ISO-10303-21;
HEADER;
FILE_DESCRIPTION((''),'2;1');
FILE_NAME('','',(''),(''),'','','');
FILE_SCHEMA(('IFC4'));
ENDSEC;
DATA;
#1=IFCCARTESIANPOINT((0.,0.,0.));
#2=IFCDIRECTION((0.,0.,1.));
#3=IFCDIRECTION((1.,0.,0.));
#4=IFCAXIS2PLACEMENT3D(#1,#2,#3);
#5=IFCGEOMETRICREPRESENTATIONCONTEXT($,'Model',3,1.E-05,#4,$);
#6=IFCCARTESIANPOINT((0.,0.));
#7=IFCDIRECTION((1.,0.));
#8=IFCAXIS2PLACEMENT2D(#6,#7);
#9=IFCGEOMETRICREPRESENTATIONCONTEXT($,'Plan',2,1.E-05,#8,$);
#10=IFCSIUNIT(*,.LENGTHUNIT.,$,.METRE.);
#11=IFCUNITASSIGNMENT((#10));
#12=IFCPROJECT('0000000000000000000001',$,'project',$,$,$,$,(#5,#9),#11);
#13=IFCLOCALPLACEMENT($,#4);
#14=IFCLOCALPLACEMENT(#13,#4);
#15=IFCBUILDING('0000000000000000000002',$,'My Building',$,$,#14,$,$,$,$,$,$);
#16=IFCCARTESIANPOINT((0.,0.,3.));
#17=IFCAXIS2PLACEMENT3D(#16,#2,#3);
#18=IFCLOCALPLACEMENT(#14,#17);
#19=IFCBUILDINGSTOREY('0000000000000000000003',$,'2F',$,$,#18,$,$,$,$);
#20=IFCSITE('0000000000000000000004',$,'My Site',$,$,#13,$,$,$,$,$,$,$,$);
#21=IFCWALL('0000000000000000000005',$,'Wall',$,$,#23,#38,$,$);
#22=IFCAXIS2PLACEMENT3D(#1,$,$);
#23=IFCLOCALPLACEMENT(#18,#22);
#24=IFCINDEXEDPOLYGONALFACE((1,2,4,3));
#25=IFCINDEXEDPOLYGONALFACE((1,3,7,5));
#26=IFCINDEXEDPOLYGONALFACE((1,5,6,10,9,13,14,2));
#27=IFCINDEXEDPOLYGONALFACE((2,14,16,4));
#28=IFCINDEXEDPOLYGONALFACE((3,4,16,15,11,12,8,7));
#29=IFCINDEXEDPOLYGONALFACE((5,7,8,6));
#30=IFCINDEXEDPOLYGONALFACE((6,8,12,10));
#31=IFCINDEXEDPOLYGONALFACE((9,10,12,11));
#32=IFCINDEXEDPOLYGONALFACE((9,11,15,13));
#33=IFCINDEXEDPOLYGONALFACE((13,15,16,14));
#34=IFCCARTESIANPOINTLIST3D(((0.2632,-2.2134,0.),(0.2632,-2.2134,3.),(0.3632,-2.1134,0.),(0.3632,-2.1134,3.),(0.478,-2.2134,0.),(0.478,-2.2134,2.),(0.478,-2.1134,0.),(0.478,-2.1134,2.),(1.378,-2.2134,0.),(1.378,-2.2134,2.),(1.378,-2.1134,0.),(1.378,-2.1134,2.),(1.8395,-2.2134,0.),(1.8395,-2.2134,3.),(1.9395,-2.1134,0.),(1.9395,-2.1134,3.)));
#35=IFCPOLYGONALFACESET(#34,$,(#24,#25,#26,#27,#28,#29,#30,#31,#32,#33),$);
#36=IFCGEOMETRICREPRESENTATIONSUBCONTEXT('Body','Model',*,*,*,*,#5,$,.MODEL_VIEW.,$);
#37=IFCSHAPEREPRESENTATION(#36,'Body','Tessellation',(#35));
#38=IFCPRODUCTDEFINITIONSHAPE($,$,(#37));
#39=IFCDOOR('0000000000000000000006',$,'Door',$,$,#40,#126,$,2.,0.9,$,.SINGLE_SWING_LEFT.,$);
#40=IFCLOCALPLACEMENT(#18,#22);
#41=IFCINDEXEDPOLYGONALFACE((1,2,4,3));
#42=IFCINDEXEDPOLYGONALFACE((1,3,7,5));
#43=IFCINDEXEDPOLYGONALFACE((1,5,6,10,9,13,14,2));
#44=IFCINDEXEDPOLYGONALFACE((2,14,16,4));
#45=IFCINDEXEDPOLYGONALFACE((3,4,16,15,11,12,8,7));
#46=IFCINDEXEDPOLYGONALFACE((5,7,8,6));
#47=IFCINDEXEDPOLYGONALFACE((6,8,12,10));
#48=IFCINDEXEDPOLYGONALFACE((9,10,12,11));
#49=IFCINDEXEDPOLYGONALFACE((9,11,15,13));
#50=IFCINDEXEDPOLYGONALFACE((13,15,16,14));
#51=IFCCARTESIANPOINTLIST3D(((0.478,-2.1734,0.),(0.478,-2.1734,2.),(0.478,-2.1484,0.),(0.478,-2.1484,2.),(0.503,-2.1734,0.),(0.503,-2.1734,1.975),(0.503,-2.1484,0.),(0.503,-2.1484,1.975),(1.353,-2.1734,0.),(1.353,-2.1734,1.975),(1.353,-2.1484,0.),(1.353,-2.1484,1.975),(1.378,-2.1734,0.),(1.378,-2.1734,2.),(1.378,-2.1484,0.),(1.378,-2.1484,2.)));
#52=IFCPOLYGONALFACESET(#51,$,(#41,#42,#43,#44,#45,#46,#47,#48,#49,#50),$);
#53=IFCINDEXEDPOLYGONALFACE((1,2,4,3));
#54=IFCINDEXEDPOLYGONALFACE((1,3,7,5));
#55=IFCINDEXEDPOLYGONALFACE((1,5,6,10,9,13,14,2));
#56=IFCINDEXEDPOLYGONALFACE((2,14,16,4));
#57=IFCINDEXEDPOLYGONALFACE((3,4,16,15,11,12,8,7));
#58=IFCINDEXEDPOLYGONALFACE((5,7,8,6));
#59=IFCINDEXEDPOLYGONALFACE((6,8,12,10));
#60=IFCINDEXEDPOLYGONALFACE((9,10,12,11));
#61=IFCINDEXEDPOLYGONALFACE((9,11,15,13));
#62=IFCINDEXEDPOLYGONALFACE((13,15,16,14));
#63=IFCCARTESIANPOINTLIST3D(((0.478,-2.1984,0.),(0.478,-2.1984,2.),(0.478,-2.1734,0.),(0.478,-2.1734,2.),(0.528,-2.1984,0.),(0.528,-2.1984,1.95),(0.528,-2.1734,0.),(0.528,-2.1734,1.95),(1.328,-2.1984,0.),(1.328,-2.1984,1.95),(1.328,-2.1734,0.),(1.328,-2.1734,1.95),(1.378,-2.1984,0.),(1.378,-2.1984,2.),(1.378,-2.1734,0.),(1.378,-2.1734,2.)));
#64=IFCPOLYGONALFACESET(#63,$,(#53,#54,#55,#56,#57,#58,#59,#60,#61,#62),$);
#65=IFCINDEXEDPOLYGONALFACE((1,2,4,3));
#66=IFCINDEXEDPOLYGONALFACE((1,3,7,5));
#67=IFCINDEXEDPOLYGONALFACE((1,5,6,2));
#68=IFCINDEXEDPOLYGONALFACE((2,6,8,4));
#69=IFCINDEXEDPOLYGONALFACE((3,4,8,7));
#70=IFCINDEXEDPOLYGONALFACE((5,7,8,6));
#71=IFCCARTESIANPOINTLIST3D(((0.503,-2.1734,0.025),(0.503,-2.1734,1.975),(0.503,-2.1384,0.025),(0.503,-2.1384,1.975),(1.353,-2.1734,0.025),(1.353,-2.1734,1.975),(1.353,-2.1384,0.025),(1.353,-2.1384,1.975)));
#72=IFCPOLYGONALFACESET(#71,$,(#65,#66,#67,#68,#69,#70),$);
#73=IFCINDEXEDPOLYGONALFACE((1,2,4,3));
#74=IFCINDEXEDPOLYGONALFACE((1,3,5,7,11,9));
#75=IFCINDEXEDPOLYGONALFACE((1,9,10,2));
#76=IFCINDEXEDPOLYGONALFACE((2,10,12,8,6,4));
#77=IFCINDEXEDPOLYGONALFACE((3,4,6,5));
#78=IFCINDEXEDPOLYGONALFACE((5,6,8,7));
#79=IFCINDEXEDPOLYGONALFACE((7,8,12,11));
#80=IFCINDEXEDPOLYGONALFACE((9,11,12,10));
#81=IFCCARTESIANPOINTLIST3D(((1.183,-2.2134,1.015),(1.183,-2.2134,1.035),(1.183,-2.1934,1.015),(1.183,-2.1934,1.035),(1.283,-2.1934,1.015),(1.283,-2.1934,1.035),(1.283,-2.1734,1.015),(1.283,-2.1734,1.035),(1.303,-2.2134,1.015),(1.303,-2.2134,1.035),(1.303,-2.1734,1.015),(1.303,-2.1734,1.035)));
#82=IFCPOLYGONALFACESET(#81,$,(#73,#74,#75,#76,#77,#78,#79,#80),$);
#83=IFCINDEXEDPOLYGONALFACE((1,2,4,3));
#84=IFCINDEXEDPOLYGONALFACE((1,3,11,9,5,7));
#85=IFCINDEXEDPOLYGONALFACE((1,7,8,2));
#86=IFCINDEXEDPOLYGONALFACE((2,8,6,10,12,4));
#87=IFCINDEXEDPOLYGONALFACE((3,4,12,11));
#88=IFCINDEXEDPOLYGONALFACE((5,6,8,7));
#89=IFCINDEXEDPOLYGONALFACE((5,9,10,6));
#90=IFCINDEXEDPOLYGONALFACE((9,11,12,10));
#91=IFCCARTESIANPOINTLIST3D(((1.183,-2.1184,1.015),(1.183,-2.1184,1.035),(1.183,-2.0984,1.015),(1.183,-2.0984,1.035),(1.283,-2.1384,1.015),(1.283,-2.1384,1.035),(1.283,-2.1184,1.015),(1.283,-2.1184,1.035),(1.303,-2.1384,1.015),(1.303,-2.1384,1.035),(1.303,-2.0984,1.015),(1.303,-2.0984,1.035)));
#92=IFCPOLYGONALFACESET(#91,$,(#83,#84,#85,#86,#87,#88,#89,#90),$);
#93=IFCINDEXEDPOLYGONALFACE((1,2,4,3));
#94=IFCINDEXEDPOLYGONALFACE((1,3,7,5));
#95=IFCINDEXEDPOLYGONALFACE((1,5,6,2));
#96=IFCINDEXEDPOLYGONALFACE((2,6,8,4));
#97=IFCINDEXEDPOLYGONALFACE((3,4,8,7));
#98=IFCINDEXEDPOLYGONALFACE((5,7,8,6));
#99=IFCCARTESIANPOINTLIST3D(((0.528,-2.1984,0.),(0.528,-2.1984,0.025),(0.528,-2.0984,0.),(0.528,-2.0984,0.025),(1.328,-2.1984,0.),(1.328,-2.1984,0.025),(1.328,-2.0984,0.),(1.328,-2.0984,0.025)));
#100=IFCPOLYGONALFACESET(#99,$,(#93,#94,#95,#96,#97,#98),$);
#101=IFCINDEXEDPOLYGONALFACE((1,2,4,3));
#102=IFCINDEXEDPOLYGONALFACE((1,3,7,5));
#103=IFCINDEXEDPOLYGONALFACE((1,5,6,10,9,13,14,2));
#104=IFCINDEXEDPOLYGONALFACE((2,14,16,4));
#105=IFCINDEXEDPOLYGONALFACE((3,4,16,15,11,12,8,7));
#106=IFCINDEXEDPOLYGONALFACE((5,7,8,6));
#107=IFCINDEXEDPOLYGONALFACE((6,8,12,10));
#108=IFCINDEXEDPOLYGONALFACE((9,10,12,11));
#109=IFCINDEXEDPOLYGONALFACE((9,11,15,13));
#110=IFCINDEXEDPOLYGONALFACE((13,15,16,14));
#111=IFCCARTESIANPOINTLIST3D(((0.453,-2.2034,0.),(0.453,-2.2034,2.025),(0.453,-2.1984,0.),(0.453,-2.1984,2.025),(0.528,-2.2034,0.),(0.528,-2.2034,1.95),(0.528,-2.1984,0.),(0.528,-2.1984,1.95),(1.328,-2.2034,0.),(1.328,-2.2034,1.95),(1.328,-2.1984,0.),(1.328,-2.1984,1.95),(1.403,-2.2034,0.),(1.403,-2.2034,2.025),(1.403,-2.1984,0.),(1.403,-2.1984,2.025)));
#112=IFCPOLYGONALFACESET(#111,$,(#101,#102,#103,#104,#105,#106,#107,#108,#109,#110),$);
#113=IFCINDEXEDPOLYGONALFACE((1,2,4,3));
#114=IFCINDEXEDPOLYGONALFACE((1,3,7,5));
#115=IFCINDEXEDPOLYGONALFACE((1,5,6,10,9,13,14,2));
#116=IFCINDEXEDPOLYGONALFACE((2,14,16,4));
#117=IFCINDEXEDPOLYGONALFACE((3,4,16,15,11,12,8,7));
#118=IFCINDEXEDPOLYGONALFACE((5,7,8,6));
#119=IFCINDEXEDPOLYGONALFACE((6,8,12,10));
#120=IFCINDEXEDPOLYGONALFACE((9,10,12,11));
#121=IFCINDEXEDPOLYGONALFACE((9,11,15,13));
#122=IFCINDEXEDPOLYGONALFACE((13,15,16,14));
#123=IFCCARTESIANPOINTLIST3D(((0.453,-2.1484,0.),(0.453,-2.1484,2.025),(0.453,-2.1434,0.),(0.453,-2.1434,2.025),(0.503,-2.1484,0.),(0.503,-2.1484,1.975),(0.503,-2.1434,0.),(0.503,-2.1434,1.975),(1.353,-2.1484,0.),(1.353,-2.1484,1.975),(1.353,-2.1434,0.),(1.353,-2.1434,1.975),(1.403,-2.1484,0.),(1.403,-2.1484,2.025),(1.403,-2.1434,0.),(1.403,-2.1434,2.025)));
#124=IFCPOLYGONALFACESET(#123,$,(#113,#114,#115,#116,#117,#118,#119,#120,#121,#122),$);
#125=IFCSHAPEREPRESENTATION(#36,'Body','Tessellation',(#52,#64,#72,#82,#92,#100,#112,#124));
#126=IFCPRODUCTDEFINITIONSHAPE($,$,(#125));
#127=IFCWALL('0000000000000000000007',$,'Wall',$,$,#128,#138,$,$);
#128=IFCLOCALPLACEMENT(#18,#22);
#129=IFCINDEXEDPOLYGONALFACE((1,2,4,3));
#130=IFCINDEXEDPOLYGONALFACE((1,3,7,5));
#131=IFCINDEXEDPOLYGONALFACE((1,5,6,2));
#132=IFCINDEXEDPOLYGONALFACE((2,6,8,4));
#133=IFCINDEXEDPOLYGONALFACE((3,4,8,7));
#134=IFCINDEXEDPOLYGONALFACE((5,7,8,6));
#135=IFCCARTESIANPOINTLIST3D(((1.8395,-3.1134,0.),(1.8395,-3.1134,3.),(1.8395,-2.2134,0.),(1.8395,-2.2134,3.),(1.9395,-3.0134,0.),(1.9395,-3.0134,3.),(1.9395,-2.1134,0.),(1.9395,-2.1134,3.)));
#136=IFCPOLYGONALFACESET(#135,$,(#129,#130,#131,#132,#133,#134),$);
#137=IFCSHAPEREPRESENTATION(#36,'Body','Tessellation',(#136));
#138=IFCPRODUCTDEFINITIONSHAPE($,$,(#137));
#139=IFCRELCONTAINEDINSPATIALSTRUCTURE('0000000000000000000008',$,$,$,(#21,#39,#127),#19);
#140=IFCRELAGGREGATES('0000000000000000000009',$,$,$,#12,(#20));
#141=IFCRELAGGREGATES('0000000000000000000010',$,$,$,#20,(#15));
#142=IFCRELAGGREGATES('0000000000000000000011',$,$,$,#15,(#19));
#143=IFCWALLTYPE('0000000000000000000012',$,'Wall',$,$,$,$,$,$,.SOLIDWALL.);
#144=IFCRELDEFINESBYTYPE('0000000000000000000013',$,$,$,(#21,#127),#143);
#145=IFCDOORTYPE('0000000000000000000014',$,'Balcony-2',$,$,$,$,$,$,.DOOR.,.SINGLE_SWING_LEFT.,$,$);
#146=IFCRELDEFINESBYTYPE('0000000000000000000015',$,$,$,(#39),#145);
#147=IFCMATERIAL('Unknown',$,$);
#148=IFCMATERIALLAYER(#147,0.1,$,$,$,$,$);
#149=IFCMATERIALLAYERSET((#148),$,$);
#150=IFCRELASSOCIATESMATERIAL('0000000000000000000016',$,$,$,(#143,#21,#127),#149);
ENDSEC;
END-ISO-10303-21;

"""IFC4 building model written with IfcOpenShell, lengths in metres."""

from ifc_helpers import new_model, entity, si_unit, frame, origin_with_axes, origin_2d_with_axis, place, context, subcontext, project, spatial, line, indexed_curve, outline, extrude, shape, source, transform, mapped, material, layer, layer_set, layer_usage, type_object, type_shapes, element, fill, save


model = new_model("IFC4")

# Units and contexts
model_context_1 = context("Model", 3, precision=1e-05, world=origin_with_axes())
plan_context = context("Plan", 2, precision=1e-05, world=origin_2d_with_axis())
body_context_1 = subcontext(model_context_1, "Body", "Model", "MODEL_VIEW")
body_context_2 = subcontext(plan_context, "Body", "Plan", "PLAN_VIEW")
ifc_project = project(units=[si_unit("LENGTHUNIT", "METRE")], contexts=[model_context_1, plan_context])

# Site, building, storey
site_placement = place(None, origin_with_axes())
site = spatial("IfcSite", under=ifc_project, at=site_placement, Name="My Site")
building_placement = place(site_placement, origin_with_axes())
building = spatial("IfcBuilding", under=site, at=building_placement, Name="My Building")
storey_placement = place(building_placement, frame((0.0, 0.0, 3.0), z_axis=(0.0, 0.0, 1.0), x_axis=(1.0, 0.0, 0.0)))
storey = spatial("IfcBuildingStorey", under=building, at=storey_placement, Name="2F")

# Wall, opening, door
ifc_material_1 = material(Name="Unknown")
ifc_layer = layer(ifc_material_1, 0.1)
ifc_layer_set = layer_set([ifc_layer])
wall_type = type_object("IfcWallType", Name="Wall", PredefinedType="SOLIDWALL", material=ifc_layer_set)
ifc_layer_usage_1 = layer_usage(ifc_layer_set, "AXIS2", "POSITIVE", 0.0)
wall_1_placement = place(storey_placement, frame((0.2632, -2.2134, 0.0), z_axis=(0.0, 0.0, 1.0), x_axis=(1.0, 0.0, 0.0)))
wall_1 = element("IfcWall", 1, at=wall_1_placement, inside=storey, type_object=wall_type, material=ifc_layer_usage_1, Name="Wall", context=body_context_1, shape_type="SweptSolid", body=[
    extrude(outline(indexed_curve([(0.0, 0.0), (0.1, 0.1), (1.6764, 0.1), (1.5764, 0.0)], segments=[line(1, 2, 3, 4, 1)])), origin_with_axes(), (0.0, 0.0, 1.0), 3.0),
])
shared_shape_1 = source(origin_with_axes(), body_context_1, "Body", "SweptSolid", [
    extrude(outline(indexed_curve([(0.0, 0.0), (0.9, 0.0), (0.9, 2.0), (0.0, 2.0)], segments=[line(1, 2, 3, 4, 1)])), frame((0.0, -0.6, 0.0), z_axis=(0.0, -1.0, 0.0), x_axis=(1.0, 0.0, 0.0)), (0.0, 0.0, -1.0), 1.2),
])
opening_1_placement = place(wall_1_placement, frame((0.2148, 0.015, 0.0), z_axis=(0.0, 0.0, 1.0), x_axis=(1.0, 0.0, 0.0)))
opening_1 = element("IfcOpeningElement", 2, at=opening_1_placement, cuts=wall_1, PredefinedType="OPENING", context=body_context_1, shape_type="MappedRepresentation", body=[
    mapped(shared_shape_1, transform((0.0, 0.0, 0.0), x_axis=(1.0, 0.0, 0.0), y_axis=(0.0, 1.0, 0.0), z_axis=(0.0, 0.0, 1.0), scale=1.0)),
])
door_type_1 = type_object("IfcDoorType", Name="Balcony-2", OperationType="SINGLE_SWING_LEFT", PredefinedType="DOOR")
shared_shape_2 = source(origin_with_axes(), body_context_1, "Body", "SweptSolid", [
    extrude(outline(indexed_curve([(0.0, 0.0), (0.0, 2.0), (0.9, 2.0), (0.9, 0.0), (0.875, 0.0), (0.875, 1.975), (0.025, 1.975), (0.025, 0.0)], segments=[line(1, 2, 3, 4, 5, 6, 7, 8, 1)])), frame((0.0, 0.025, 0.0), z_axis=(0.0, -1.0, 0.0), x_axis=(1.0, 0.0, 0.0)), (0.0, 0.0, -1.0), 0.025),
    extrude(outline(indexed_curve([(0.0, 0.0), (0.0, 2.0), (0.9, 2.0), (0.9, 0.0), (0.85, 0.0), (0.85, 1.95), (0.05, 1.95), (0.05, 0.0)], segments=[line(1, 2, 3, 4, 5, 6, 7, 8, 1)])), frame((0.0, 0.0, 0.0), z_axis=(0.0, -1.0, 0.0), x_axis=(1.0, 0.0, 0.0)), (0.0, 0.0, -1.0), 0.025),
    extrude(outline(indexed_curve([(0.0, 0.0), (0.85, 0.0), (0.85, 0.035), (0.0, 0.035)], segments=[line(1, 2, 3, 4, 1)])), frame((0.025, 0.025, 0.025), z_axis=(0.0, 0.0, 1.0), x_axis=(1.0, 0.0, 0.0)), (0.0, 0.0, 1.0), 1.95),
    extrude(outline(indexed_curve([(0.0, 0.0), (0.0, -0.04), (-0.12, -0.04), (-0.12, -0.02), (-0.02, -0.02), (-0.02, 0.0)], segments=[line(1, 2, 3, 4, 5, 6, 1)])), frame((0.825, 0.025, 1.015), z_axis=(0.0, 0.0, 1.0), x_axis=(1.0, 0.0, 0.0)), (0.0, 0.0, 1.0), 0.02),
    extrude(outline(indexed_curve([(0.0, 0.0), (0.0, 0.04), (-0.12, 0.04), (-0.12, 0.02), (-0.02, 0.02), (-0.02, 0.0)], segments=[line(1, 2, 3, 4, 5, 6, 1)])), frame((0.825, 0.06, 1.015), z_axis=(0.0, 0.0, 1.0), x_axis=(1.0, 0.0, 0.0)), (0.0, 0.0, 1.0), 0.02),
    extrude(outline(indexed_curve([(0.0, 0.0), (0.8, 0.0), (0.8, 0.1), (0.0, 0.1)], segments=[line(1, 2, 3, 4, 1)])), frame((0.05, 0.0, 0.0), z_axis=(0.0, 0.0, 1.0), x_axis=(1.0, 0.0, 0.0)), (0.0, 0.0, 1.0), 0.025),
    extrude(outline(indexed_curve([(0.0, 0.0), (0.0, 2.025), (0.95, 2.025), (0.95, 0.0), (0.875, 0.0), (0.875, 1.95), (0.075, 1.95), (0.075, 0.0)], segments=[line(1, 2, 3, 4, 5, 6, 7, 8, 1)])), frame((-0.025, -0.005, 0.0), z_axis=(0.0, -1.0, 0.0), x_axis=(1.0, 0.0, 0.0)), (0.0, 0.0, -1.0), 0.005),
    extrude(outline(indexed_curve([(0.0, 0.0), (0.0, 2.025), (0.95, 2.025), (0.95, 0.0), (0.9, 0.0), (0.9, 1.975), (0.05, 1.975), (0.05, 0.0)], segments=[line(1, 2, 3, 4, 5, 6, 7, 8, 1)])), frame((-0.025, 0.05, 0.0), z_axis=(0.0, -1.0, 0.0), x_axis=(1.0, 0.0, 0.0)), (0.0, 0.0, -1.0), 0.005),
])
shared_shape_3 = source(origin_with_axes(), body_context_2, "Body", "Curve2D", [
    entity("IfcIndexedPolyCurve", entity("IfcCartesianPointList2D", [[0.0, 0.0], [0.0, 0.05], [0.025, 0.05], [0.025, 0.025], [0.05, 0.025], [0.05, 0.0]]), [entity("IfcLineIndex", [1, 2, 3, 4, 5, 6, 1])]),
    entity("IfcIndexedPolyCurve", entity("IfcCartesianPointList2D", [[0.9, 0.0], [0.9, 0.05], [0.875, 0.05], [0.875, 0.025], [0.85, 0.025], [0.85, 0.0]]), [entity("IfcLineIndex", [1, 2, 3, 4, 5, 6, 1])]),
    entity("IfcTrimmedCurve", entity("IfcEllipse", entity("IfcAxis2Placement2D", entity("IfcCartesianPoint", [0.06, 0.05]), entity("IfcDirection", [1.0, 0.0])), 0.815, 0.85), [entity("IfcCartesianPoint", [0.875, 0.05])], [entity("IfcCartesianPoint", [0.06, 0.9])], True, "CARTESIAN"),
    entity("IfcIndexedPolyCurve", entity("IfcCartesianPointList2D", [[0.025, 0.05], [0.06, 0.05], [0.06, 0.9], [0.025, 0.9]]), [entity("IfcLineIndex", [1, 2, 3, 4, 1])]),
])
type_shapes(door_type_1, [shared_shape_2, shared_shape_3])
door_1_placement = place(opening_1_placement, frame((0.0, 0.0, 0.0), z_axis=(0.0, 0.0, 1.0), x_axis=(1.0, 0.0, 0.0)))
door_1 = element("IfcDoor", 3, at=door_1_placement, inside=storey, type_object=door_type_1, Name="Door", OperationType="SINGLE_SWING_LEFT", OverallHeight=2.0, OverallWidth=0.9, shapes=[
    shape(body_context_1, "Body", "MappedRepresentation", [mapped(shared_shape_2, transform((0.0, 0.0, 0.0), x_axis=(1.0, 0.0, 0.0), y_axis=(0.0, 1.0, 0.0), z_axis=(0.0, 0.0, 1.0), scale=1.0))]),
    shape(body_context_2, "Body", "MappedRepresentation", [mapped(shared_shape_3, transform((0.0, 0.0, 0.0), x_axis=(1.0, 0.0, 0.0), y_axis=(0.0, 1.0, 0.0), z_axis=(0.0, 0.0, 1.0), scale=1.0))]),
])
fill(opening_1, door_1)

# Wall
ifc_layer_usage_2 = layer_usage(ifc_layer_set, "AXIS2", "POSITIVE", 0.0)
wall_2_placement = place(storey_placement, frame((1.8395, -2.2134, 0.0), z_axis=(0.0, 0.0, 1.0), x_axis=(0.0, -1.0, 0.0)))
element("IfcWall", 4, at=wall_2_placement, inside=storey, type_object=wall_type, material=ifc_layer_usage_2, Name="Wall", context=body_context_1, shape_type="SweptSolid", body=[
    extrude(outline(indexed_curve([(0.0, 0.0), (-0.1, 0.1), (0.8, 0.1), (0.9, 0.0)], segments=[line(1, 2, 3, 4, 1)])), origin_with_axes(), (0.0, 0.0, 1.0), 3.0),
])

save(model, "model.ifc")
